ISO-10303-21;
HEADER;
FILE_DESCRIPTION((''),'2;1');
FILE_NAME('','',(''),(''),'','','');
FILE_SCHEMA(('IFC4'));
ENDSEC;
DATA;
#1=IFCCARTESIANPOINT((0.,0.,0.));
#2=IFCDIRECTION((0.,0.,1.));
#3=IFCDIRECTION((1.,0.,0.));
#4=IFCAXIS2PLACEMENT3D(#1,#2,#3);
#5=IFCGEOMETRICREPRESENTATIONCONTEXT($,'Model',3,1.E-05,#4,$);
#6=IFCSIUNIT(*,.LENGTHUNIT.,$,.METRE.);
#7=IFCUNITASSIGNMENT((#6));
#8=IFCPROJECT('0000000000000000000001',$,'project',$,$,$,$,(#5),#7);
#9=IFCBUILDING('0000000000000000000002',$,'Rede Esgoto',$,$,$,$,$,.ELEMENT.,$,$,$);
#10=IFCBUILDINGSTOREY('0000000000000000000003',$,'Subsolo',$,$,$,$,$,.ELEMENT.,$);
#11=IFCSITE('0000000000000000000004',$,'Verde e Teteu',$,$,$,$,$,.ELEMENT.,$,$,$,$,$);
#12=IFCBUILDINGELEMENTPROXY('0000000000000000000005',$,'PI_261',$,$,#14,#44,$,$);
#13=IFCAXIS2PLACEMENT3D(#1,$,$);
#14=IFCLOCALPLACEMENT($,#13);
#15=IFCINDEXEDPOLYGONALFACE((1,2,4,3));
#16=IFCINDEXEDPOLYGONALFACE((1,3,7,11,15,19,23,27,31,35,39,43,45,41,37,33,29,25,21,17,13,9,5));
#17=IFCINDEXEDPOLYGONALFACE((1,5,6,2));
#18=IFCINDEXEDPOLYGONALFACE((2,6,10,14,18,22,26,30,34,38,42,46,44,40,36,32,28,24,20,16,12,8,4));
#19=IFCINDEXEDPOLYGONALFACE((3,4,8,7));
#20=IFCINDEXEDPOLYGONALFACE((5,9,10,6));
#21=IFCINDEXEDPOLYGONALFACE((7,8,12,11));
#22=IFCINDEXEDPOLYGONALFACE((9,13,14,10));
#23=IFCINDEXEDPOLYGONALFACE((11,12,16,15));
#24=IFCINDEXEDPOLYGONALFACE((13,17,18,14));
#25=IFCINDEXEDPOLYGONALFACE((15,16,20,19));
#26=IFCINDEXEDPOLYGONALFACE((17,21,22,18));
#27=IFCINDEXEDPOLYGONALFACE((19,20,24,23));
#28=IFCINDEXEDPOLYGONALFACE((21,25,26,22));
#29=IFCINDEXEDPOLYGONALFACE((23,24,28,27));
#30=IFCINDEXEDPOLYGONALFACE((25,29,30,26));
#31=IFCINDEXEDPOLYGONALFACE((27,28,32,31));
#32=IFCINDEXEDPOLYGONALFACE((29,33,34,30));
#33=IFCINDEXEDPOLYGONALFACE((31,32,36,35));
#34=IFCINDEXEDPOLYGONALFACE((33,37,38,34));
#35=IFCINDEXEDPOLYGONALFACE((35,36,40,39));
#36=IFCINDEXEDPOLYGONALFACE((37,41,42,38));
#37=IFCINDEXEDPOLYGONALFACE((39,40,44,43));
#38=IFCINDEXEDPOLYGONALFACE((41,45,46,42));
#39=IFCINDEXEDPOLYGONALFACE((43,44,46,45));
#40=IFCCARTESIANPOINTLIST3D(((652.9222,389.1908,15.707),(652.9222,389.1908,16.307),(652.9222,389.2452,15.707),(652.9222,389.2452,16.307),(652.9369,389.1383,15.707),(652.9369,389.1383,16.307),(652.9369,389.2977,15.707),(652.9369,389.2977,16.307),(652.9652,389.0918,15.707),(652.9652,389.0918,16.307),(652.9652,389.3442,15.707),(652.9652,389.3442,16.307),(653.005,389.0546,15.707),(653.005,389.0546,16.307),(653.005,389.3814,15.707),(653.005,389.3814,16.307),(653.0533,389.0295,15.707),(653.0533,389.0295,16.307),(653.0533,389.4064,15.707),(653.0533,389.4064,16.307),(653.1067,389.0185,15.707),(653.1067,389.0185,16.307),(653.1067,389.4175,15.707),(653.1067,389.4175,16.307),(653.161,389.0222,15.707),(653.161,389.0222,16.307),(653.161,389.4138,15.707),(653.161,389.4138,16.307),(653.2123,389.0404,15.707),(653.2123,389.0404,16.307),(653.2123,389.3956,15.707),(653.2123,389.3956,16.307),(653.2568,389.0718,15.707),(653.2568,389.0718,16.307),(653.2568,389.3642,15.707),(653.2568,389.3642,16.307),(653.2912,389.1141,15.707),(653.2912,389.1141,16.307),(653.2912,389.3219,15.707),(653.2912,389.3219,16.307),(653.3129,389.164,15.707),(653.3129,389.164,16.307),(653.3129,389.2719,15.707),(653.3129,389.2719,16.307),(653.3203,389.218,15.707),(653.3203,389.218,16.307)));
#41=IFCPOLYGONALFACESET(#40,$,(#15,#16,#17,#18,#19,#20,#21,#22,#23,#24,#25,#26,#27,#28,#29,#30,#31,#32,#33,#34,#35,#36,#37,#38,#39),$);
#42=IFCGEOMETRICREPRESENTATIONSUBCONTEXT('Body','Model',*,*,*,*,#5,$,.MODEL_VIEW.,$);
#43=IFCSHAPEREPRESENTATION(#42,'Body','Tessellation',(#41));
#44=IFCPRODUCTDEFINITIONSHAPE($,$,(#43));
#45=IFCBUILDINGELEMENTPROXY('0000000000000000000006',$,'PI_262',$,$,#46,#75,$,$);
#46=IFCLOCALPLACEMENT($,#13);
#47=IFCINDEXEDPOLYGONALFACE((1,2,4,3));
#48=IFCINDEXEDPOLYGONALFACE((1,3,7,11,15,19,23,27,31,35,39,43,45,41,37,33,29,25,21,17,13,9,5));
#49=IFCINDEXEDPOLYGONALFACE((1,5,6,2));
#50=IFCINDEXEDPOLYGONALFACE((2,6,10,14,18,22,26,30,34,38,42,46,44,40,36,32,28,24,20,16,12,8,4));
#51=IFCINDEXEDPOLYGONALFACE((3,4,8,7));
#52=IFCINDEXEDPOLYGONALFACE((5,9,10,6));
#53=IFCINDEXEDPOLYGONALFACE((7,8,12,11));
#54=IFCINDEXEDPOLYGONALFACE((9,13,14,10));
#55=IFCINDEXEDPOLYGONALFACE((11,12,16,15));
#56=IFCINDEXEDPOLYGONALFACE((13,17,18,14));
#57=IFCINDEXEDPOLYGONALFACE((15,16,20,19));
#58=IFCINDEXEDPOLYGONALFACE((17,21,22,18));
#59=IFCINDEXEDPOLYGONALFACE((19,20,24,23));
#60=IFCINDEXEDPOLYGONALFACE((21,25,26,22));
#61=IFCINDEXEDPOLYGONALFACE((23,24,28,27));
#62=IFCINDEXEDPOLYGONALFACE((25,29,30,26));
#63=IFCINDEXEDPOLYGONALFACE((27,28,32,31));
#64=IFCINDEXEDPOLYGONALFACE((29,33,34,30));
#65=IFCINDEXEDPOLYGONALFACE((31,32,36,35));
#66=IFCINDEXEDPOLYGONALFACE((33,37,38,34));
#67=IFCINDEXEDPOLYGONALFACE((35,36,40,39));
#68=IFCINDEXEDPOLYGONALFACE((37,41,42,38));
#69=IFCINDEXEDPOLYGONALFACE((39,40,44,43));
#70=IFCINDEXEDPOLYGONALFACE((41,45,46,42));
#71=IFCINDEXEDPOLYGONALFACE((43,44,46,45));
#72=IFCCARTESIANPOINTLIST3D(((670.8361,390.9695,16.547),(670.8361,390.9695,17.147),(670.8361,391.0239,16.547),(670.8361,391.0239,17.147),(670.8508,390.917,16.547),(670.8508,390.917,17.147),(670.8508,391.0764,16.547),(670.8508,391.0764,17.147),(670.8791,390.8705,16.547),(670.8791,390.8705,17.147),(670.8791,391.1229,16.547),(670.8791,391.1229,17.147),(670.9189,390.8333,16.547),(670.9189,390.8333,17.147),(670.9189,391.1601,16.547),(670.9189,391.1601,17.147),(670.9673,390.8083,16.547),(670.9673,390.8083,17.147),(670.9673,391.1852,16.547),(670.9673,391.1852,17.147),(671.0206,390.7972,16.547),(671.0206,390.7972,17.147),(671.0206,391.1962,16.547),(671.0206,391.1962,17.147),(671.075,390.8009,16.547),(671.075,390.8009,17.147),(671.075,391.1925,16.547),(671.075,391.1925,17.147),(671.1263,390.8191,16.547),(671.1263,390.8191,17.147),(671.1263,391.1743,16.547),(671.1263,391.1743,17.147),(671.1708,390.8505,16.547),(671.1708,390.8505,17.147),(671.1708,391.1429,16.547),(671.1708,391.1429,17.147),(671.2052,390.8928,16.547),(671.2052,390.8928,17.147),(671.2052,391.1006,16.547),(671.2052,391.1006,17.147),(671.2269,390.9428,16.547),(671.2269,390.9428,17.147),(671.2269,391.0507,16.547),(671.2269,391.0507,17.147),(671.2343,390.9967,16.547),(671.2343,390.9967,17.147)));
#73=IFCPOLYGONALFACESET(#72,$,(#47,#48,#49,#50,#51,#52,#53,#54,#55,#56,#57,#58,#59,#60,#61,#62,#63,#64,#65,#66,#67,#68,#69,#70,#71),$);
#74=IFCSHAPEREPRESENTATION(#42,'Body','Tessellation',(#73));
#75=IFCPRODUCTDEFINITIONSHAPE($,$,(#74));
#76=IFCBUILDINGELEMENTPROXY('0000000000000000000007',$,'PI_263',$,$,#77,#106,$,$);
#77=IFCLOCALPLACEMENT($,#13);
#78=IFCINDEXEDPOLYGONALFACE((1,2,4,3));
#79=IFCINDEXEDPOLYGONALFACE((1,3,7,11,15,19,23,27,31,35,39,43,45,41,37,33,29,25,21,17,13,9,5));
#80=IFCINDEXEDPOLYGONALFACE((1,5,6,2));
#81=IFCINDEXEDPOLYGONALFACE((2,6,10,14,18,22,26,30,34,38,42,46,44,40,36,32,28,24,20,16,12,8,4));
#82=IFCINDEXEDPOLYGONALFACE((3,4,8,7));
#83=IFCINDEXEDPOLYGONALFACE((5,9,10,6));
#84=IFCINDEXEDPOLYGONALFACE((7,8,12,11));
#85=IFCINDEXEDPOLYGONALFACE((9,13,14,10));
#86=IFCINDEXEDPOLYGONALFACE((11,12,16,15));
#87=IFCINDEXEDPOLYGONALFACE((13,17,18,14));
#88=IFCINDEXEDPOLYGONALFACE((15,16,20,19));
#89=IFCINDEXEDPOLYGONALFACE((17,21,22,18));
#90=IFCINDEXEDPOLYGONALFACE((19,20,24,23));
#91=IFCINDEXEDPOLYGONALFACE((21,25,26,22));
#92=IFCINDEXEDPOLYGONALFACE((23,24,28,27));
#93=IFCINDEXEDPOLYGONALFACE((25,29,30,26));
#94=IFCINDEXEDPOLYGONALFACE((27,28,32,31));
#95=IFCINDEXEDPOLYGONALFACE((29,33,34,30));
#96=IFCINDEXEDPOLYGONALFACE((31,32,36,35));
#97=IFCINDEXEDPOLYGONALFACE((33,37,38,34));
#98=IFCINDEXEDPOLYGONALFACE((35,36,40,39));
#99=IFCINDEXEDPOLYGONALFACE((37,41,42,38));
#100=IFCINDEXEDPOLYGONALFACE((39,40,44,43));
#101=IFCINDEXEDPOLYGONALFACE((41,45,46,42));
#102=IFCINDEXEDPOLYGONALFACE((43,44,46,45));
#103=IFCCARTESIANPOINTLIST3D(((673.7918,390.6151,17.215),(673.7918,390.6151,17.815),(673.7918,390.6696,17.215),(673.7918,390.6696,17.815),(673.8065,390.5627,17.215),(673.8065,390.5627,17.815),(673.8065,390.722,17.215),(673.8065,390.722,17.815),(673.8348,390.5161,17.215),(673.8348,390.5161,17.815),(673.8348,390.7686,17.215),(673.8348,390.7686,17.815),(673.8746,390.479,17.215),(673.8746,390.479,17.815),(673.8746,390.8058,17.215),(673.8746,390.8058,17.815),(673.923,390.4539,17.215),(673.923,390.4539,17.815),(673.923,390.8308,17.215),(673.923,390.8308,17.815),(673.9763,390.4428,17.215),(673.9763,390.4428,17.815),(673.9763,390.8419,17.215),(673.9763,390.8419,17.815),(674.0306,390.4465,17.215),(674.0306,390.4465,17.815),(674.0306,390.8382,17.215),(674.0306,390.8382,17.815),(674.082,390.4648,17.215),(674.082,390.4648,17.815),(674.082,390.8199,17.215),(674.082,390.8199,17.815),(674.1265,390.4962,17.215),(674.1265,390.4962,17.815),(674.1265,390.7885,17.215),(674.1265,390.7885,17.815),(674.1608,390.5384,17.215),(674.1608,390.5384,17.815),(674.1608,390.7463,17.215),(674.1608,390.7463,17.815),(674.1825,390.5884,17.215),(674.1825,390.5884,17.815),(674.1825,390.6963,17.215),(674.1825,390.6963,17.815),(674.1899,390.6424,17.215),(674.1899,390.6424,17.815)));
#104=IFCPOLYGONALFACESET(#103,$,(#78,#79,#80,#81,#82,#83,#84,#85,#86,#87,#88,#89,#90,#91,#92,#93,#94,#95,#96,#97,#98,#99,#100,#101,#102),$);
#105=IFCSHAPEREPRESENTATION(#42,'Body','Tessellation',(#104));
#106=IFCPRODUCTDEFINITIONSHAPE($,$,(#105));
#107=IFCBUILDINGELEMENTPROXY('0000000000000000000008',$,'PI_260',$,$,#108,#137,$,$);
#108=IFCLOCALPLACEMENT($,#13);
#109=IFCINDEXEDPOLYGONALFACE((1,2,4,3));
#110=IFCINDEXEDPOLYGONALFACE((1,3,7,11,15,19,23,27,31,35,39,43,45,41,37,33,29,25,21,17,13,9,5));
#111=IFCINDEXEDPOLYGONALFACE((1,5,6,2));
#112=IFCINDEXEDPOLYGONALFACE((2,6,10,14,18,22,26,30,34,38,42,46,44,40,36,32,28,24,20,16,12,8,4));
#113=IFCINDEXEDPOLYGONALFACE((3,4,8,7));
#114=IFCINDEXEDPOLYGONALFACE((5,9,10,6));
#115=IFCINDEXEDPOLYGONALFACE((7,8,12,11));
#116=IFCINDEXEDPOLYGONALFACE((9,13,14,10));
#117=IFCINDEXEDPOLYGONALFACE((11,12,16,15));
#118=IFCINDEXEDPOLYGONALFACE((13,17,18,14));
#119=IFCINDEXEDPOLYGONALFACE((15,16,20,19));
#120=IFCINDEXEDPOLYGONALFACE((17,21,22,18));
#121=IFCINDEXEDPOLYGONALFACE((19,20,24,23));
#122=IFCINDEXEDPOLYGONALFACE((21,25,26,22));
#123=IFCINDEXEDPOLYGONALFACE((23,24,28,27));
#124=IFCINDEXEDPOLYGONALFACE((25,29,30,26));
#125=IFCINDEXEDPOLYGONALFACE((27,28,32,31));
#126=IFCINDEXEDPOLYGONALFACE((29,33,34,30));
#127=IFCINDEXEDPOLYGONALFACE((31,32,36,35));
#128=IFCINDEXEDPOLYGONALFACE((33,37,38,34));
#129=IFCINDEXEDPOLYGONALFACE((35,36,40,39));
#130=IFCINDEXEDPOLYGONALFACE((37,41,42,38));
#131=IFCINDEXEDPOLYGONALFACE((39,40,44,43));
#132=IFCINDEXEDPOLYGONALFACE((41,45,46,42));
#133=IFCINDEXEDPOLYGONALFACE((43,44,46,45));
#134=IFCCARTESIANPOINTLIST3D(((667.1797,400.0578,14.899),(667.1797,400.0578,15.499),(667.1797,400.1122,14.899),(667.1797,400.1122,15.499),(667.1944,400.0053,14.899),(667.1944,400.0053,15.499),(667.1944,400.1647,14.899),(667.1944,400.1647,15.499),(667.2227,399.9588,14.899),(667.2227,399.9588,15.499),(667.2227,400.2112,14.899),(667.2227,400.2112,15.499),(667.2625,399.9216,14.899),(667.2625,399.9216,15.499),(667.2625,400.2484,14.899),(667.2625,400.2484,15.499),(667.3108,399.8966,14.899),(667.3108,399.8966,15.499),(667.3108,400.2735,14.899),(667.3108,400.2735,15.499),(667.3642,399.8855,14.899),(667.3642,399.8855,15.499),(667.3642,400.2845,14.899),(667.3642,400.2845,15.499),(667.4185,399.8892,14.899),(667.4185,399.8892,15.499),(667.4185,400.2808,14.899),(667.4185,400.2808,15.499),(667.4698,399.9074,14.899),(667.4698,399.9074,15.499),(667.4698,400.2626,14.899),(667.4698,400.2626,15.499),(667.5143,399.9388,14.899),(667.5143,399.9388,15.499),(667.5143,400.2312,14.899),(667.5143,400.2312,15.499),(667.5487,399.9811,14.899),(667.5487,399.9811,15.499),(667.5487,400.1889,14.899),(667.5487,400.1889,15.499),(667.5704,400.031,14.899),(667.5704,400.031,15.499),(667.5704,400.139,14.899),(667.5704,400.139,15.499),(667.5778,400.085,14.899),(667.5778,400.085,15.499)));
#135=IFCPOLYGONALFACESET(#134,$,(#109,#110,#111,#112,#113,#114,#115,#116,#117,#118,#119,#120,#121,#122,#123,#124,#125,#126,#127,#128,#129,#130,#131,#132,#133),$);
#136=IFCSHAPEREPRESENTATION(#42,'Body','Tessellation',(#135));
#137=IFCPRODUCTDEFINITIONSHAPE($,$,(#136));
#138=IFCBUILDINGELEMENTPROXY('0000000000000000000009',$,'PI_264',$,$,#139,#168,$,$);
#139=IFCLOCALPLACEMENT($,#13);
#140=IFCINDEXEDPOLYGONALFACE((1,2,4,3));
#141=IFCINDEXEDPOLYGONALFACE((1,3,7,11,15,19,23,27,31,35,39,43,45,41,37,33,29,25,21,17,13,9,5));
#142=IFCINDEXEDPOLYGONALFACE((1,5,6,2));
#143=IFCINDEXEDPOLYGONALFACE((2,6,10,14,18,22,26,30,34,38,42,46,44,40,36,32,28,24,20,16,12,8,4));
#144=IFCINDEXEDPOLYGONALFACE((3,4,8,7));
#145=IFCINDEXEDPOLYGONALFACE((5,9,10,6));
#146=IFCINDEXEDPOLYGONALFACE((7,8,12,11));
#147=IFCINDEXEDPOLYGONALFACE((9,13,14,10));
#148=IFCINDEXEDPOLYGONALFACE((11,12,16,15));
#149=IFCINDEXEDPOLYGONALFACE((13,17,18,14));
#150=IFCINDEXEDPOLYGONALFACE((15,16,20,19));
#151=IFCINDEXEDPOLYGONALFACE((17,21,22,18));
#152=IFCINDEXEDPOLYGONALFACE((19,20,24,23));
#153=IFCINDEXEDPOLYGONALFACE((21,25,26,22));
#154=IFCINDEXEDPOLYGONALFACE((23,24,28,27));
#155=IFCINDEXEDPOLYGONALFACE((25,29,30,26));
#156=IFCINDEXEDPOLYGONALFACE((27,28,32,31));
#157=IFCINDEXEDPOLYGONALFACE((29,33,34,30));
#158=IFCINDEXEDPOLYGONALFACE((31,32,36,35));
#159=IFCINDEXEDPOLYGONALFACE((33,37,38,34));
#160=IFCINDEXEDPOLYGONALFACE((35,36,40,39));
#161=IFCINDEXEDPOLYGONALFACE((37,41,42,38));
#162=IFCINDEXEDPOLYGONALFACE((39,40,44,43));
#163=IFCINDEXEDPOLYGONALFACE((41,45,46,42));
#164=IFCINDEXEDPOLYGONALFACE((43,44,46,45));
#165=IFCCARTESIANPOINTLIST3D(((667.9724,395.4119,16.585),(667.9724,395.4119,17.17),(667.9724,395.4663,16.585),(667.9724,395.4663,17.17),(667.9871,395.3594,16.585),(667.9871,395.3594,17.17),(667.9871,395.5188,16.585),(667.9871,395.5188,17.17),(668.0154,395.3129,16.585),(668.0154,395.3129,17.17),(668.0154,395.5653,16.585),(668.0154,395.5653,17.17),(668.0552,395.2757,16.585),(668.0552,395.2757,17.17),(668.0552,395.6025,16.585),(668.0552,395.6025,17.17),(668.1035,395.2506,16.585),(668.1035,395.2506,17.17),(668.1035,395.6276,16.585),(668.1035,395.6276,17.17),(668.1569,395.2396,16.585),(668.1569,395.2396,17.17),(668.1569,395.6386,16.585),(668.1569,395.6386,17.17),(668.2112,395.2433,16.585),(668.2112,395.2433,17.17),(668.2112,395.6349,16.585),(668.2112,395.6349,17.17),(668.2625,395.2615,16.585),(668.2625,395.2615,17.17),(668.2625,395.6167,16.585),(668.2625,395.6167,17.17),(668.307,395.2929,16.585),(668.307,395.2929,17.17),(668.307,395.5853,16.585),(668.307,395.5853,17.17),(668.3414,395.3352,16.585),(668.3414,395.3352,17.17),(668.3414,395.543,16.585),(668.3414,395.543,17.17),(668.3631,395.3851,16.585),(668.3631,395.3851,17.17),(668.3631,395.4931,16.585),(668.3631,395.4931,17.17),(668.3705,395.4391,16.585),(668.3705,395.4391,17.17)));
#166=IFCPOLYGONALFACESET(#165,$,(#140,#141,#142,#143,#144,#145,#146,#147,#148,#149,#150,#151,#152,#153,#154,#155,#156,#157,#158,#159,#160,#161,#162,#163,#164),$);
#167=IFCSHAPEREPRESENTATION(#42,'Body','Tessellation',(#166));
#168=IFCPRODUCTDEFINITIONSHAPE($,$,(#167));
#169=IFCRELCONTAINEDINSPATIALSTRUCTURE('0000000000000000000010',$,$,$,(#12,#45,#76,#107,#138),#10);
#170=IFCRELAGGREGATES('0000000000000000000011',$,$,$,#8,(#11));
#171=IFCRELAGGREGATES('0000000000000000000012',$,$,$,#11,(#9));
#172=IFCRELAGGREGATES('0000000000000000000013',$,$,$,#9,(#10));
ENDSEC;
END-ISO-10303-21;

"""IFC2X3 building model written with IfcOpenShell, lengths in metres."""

from ifc_helpers import new_model, si_unit, frame, origin_with_axes, origin_2d, place, context, subcontext, project, spatial, circle, extrude, element, save


model = new_model("IFC2X3")

# Units and contexts
model_context = context("Model", 3, precision=1e-05, world=origin_with_axes())
body_context = subcontext(model_context, "Body", "Model", "MODEL_VIEW")
ifc_project = project(units=[si_unit("LENGTHUNIT", "METRE")], contexts=[model_context])

# Site, building, storey
site = spatial("IfcSite", under=ifc_project, Name="Verde e Teteu", CompositionType="ELEMENT")
building = spatial("IfcBuilding", under=site, Name="Rede Esgoto", CompositionType="ELEMENT")
storey = spatial("IfcBuildingStorey", under=building, Name="Subsolo", CompositionType="ELEMENT")

# Building element proxies
for number, where, z_axis, x_axis, name in (
    (1, (653.1203, 389.218, 15.707), (0.0, 0.0, 1.0), (1.0, 0.0, 0.0), "PI_261"),
    (2, (671.0343, 390.9967, 16.547), (0.0, 0.0, 1.0), (1.0, 0.0, 0.0), "PI_262"),
):
    element("IfcBuildingElementProxy", number, at=place(None, frame(where, z_axis=z_axis, x_axis=x_axis)), inside=storey, Name=name, context=body_context, shape_type="SweptSolid", body=[
        extrude(circle(Radius=0.2, at=origin_2d()), origin_with_axes(), (0.0, 0.0, 1.0), 0.6),
    ])
for number, where, z_axis, x_axis, name in (
    (3, (673.9899, 390.6424, 17.215), (0.0, 0.0, 1.0), (1.0, 0.0, 0.0), "PI_263"),
    (4, (667.3778, 400.085, 14.899), (0.0, 0.0, 1.0), (1.0, 0.0, 0.0), "PI_260"),
):
    element("IfcBuildingElementProxy", number, at=place(None, frame(where, z_axis=z_axis, x_axis=x_axis)), inside=storey, Name=name, context=body_context, shape_type="SweptSolid", body=[
        extrude(circle(Radius=0.2, at=origin_2d()), origin_with_axes(), (0.0, 0.0, 1.0), 0.6),
    ])
proxy_1_placement = place(None, frame((668.1705, 395.4391, 16.585), z_axis=(0.0, 0.0, 1.0), x_axis=(1.0, 0.0, 0.0)))
element("IfcBuildingElementProxy", 5, at=proxy_1_placement, inside=storey, Name="PI_264", context=body_context, shape_type="SweptSolid", body=[
    extrude(circle(Radius=0.2, at=origin_2d()), origin_with_axes(), (0.0, 0.0, 1.0), 0.585),
])

save(model, "model.ifc")
